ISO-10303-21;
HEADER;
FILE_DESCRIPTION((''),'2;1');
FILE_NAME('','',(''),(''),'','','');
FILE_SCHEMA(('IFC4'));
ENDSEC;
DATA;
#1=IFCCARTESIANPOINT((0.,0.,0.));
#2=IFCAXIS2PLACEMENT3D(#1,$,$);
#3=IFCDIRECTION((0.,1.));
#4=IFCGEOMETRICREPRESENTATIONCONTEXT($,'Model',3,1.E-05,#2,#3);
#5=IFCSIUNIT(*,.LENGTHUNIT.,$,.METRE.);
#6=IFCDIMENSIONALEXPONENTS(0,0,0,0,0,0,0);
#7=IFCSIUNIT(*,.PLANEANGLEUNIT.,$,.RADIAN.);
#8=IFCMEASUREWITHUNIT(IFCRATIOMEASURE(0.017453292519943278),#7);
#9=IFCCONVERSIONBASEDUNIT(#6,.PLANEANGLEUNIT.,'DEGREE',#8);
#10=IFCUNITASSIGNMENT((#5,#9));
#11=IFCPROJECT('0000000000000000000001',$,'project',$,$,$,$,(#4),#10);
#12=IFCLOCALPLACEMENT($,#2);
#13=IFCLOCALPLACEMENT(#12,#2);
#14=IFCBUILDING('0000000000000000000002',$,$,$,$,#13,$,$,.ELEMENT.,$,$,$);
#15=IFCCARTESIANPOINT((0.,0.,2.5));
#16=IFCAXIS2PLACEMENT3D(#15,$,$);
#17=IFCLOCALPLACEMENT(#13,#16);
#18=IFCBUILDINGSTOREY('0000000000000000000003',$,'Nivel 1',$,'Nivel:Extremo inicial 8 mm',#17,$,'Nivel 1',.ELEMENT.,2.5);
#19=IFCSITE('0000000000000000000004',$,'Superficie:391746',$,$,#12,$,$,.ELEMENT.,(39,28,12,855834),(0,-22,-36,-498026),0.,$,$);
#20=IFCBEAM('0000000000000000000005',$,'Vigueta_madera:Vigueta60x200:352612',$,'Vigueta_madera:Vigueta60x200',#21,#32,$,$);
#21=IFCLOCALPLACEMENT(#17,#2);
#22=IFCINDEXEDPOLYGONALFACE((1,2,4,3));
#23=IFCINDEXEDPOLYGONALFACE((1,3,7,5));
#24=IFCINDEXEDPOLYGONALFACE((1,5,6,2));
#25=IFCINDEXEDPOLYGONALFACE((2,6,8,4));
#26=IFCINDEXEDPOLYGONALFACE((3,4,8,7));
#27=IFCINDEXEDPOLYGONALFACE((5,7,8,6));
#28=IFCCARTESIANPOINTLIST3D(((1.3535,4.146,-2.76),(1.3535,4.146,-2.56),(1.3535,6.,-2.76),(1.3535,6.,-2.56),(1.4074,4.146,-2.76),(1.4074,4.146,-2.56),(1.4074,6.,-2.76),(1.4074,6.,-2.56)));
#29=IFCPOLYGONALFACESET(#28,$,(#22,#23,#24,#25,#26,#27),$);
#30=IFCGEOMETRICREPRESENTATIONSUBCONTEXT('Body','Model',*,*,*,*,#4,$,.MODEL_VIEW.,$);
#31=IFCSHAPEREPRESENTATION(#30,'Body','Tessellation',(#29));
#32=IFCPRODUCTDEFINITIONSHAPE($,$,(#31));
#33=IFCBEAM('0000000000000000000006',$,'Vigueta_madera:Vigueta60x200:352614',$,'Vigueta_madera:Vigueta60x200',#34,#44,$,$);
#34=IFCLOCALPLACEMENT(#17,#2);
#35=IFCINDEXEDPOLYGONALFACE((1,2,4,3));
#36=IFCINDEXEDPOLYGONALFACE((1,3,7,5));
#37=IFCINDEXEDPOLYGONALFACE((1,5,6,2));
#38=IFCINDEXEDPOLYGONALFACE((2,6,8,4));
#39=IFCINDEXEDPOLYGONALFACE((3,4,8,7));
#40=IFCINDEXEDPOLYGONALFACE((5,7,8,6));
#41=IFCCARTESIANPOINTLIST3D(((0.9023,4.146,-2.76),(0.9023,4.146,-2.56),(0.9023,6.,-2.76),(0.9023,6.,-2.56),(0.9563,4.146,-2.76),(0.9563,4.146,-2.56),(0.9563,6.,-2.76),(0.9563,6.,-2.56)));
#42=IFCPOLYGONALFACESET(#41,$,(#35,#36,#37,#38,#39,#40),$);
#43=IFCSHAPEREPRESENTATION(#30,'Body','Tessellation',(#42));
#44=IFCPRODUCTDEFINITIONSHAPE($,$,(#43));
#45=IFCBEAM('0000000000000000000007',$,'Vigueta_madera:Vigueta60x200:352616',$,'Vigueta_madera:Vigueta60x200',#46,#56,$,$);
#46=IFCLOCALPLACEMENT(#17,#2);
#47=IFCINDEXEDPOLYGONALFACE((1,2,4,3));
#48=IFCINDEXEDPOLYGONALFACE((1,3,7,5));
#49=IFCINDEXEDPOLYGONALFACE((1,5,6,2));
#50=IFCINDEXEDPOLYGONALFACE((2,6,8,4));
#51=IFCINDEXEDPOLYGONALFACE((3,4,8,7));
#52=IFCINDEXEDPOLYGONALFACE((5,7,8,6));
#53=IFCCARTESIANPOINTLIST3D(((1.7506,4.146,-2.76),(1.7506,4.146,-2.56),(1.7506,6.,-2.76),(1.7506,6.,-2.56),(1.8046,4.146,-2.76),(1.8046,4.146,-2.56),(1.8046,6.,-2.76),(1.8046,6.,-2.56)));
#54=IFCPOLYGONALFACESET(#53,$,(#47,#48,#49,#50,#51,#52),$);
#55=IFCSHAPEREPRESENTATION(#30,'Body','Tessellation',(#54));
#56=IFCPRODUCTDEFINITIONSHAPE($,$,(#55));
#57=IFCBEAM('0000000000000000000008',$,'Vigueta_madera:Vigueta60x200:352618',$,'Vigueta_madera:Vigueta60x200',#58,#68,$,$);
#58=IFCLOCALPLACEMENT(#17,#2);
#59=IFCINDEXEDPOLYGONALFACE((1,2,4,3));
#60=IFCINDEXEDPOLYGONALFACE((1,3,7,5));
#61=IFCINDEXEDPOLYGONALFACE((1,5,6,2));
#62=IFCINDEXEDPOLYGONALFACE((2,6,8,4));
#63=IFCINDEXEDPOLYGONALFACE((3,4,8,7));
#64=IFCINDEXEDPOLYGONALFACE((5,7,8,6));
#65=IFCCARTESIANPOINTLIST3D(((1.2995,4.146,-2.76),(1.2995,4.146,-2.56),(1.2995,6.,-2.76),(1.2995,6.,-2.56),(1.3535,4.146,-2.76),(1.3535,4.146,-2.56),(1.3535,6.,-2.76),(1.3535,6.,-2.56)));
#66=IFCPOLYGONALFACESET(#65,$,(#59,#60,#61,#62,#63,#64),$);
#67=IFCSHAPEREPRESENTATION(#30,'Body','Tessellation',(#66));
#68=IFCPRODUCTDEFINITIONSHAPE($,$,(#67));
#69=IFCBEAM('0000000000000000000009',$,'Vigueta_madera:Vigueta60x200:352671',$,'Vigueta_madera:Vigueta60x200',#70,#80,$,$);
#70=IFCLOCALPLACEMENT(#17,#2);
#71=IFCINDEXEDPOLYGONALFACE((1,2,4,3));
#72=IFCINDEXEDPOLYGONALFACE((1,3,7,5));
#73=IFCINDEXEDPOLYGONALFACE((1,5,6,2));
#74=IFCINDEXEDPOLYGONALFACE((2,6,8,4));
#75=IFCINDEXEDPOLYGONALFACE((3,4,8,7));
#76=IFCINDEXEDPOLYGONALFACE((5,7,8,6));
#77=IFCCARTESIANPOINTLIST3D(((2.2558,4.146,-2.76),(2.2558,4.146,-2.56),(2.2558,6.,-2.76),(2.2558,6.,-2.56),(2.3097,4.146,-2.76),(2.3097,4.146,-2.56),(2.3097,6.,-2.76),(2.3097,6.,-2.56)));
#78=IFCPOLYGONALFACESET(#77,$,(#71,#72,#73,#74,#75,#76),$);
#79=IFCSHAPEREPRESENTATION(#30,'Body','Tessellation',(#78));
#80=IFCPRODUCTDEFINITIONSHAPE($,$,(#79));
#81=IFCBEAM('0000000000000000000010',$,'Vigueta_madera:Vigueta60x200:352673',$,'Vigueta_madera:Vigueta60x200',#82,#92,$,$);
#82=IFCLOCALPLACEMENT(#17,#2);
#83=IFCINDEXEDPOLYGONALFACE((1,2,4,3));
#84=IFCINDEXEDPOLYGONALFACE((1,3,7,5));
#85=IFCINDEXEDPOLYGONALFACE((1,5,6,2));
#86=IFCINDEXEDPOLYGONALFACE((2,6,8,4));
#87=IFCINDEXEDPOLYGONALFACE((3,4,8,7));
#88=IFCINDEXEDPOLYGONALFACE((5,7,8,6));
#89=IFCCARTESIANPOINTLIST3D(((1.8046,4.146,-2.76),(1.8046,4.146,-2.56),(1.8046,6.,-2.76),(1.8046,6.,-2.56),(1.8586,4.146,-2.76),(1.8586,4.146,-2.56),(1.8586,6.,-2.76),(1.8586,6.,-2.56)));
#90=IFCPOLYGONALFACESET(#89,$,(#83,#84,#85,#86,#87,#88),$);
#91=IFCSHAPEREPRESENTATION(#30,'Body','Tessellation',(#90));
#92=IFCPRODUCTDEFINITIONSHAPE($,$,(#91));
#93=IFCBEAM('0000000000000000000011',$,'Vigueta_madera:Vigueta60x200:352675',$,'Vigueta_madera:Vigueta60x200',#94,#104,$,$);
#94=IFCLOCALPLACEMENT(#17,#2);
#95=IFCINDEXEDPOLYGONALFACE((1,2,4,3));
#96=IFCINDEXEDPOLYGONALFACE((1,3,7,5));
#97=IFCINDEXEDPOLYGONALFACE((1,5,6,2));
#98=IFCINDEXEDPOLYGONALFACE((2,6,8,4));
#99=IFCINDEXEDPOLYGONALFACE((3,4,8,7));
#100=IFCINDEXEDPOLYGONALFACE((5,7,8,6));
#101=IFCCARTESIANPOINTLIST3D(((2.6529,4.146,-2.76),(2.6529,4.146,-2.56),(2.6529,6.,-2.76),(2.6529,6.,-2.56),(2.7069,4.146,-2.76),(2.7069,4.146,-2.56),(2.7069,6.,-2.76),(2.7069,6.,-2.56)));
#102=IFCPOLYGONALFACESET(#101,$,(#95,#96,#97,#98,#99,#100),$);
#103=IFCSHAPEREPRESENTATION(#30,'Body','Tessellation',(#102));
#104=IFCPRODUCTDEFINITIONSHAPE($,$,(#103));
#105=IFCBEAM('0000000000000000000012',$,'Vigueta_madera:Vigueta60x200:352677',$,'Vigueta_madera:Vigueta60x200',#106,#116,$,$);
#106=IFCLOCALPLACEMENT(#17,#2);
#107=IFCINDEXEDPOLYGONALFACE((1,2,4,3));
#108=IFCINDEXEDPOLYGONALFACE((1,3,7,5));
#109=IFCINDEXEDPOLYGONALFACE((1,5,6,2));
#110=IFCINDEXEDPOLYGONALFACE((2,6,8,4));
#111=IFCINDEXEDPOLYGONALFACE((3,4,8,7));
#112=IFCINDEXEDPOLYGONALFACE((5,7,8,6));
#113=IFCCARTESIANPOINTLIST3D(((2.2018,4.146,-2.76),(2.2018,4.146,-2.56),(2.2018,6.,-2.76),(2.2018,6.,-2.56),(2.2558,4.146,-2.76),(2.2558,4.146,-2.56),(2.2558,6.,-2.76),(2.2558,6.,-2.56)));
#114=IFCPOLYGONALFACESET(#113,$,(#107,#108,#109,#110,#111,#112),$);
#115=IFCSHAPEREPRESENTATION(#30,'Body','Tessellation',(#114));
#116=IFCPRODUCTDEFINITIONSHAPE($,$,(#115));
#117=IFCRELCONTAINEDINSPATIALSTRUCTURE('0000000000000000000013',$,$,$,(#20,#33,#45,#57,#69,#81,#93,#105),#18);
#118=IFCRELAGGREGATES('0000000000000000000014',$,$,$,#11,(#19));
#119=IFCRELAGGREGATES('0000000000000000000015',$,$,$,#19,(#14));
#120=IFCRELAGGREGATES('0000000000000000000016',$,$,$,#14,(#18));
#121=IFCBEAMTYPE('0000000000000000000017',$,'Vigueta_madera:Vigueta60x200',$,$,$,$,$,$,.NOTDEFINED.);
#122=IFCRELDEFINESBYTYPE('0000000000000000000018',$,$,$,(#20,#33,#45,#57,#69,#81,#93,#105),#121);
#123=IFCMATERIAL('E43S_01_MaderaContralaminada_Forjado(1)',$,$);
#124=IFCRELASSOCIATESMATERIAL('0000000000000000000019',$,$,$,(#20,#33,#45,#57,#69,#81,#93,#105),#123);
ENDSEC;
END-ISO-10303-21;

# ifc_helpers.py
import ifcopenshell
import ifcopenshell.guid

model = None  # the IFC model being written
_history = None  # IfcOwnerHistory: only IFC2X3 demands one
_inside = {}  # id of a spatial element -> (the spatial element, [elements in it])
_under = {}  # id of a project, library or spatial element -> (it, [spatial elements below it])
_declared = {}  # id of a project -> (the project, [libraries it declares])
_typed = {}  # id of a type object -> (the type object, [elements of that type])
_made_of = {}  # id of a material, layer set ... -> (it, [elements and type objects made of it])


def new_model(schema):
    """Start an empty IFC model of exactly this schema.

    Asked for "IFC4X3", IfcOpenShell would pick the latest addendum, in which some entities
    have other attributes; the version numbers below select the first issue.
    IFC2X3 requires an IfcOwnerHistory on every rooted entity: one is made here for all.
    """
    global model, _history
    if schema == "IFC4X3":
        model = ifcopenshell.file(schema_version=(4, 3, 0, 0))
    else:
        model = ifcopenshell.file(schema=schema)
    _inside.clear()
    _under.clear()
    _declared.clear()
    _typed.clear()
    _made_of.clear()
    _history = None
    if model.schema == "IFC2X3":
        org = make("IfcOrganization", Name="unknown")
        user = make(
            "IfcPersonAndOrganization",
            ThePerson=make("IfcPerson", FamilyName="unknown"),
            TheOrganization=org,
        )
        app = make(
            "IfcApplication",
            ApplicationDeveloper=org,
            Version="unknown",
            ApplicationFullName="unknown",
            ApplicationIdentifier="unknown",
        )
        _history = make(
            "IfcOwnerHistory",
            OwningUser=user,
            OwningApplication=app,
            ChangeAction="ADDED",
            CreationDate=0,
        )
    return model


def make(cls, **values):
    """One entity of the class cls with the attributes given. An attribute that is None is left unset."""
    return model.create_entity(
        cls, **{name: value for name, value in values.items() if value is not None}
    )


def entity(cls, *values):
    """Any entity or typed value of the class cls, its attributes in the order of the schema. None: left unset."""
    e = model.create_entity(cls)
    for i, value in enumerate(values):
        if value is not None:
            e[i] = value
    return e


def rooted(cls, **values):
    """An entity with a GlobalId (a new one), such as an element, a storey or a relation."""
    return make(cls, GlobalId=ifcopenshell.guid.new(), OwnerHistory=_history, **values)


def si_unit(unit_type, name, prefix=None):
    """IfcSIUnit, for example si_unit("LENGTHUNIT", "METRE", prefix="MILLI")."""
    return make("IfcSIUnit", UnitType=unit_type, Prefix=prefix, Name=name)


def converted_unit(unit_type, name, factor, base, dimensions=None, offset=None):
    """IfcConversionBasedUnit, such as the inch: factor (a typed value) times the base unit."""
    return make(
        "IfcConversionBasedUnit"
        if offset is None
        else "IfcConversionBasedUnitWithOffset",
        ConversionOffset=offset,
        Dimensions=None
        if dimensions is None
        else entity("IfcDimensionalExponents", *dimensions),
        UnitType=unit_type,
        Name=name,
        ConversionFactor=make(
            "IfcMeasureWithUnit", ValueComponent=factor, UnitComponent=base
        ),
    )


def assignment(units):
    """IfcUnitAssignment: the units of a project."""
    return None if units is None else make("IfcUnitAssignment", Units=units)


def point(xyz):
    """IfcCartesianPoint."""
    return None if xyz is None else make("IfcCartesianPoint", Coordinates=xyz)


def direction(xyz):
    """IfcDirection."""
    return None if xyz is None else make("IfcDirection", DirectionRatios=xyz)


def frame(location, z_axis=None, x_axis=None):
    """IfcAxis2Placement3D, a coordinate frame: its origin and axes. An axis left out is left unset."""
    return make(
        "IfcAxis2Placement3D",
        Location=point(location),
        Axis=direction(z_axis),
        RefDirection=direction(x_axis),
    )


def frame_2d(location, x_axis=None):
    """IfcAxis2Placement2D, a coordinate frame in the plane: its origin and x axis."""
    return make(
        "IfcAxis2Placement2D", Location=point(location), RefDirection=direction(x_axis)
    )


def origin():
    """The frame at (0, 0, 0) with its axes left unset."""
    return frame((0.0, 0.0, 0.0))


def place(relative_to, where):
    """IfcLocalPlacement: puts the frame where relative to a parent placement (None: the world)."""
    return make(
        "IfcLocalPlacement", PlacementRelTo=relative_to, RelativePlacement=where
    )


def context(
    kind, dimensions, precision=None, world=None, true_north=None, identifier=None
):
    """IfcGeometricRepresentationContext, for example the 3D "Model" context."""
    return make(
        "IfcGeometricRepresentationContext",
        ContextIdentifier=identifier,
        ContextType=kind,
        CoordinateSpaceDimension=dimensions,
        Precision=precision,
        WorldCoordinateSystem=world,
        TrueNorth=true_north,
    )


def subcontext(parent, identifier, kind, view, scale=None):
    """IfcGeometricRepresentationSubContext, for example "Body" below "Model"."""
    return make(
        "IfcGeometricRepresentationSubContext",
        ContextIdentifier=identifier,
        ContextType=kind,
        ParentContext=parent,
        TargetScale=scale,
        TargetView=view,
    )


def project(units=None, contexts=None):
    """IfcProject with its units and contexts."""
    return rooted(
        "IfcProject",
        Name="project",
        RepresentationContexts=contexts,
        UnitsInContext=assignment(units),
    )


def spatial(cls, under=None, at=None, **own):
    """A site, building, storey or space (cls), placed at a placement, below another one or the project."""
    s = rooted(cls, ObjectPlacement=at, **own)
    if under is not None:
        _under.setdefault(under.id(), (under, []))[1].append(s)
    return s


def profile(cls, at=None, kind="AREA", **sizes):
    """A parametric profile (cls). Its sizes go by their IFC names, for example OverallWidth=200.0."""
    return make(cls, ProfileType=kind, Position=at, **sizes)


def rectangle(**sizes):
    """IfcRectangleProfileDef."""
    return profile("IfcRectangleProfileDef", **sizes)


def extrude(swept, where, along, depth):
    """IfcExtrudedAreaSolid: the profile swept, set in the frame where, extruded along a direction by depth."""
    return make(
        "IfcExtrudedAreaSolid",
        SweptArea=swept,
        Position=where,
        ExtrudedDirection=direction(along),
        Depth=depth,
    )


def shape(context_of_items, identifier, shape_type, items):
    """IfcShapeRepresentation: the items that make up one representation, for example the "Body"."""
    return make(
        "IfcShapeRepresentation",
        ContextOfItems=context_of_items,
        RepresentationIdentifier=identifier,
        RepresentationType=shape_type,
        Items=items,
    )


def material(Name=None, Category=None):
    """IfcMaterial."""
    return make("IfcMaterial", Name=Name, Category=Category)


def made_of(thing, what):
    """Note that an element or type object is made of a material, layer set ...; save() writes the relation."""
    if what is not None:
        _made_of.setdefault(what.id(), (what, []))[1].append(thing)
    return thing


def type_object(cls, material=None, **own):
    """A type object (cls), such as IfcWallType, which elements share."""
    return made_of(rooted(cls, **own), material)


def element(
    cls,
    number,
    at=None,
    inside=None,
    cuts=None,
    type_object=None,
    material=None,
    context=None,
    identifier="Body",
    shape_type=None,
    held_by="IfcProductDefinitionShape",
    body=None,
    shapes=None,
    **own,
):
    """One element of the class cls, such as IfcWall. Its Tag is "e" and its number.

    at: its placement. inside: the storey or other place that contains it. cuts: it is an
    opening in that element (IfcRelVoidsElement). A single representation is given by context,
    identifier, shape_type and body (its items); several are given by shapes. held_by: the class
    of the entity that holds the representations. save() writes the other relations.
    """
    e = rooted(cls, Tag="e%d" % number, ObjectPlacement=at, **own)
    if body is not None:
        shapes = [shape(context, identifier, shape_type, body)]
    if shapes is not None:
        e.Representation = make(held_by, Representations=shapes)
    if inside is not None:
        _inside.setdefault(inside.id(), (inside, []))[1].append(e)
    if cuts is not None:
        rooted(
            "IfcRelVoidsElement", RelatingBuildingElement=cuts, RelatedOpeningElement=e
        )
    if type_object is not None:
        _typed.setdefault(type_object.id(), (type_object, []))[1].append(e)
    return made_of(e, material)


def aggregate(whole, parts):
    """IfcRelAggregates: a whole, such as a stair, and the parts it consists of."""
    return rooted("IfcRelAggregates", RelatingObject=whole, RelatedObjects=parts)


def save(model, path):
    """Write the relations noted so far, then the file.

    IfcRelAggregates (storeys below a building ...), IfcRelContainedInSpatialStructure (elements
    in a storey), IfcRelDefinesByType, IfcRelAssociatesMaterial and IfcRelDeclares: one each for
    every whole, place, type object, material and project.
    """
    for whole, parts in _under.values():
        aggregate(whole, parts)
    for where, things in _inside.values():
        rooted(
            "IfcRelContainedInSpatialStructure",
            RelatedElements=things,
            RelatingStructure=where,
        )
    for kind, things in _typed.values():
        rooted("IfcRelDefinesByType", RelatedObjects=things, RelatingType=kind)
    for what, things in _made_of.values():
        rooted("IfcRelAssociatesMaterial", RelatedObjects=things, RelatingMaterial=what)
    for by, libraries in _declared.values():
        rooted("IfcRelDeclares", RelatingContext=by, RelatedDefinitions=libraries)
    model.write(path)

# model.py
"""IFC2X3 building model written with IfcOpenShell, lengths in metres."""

from ifc_helpers import new_model, entity, si_unit, converted_unit, direction, frame, frame_2d, origin, place, context, subcontext, project, spatial, rectangle, extrude, material, type_object, element, save


model = new_model("IFC2X3")

# Units and contexts
model_context = context("Model", 3, precision=1e-05, world=origin(), true_north=direction((0.0, 1.0)))
body_context = subcontext(model_context, "Body", "Model", "MODEL_VIEW")
ifc_project = project(units=[si_unit("LENGTHUNIT", "METRE"), converted_unit("PLANEANGLEUNIT", "DEGREE", entity("IfcRatioMeasure", 0.017453292519943278), si_unit("PLANEANGLEUNIT", "RADIAN"), dimensions=[0, 0, 0, 0, 0, 0, 0])], contexts=[model_context])

# Site, building, storey
site_placement = place(None, origin())
site = spatial("IfcSite", under=ifc_project, at=site_placement, Name="Superficie:391746", CompositionType="ELEMENT", RefLatitude=(39, 28, 12, 855834), RefLongitude=(0, -22, -36, -498026), RefElevation=0.0)
building_placement = place(site_placement, origin())
building = spatial("IfcBuilding", under=site, at=building_placement, CompositionType="ELEMENT")
storey_placement = place(building_placement, frame((0.0, 0.0, 2.5)))
storey = spatial("IfcBuildingStorey", under=building, at=storey_placement, Name="Nivel 1", ObjectType="Nivel:Extremo inicial 8 mm", LongName="Nivel 1", CompositionType="ELEMENT", Elevation=2.5)

# Beams
ifc_material = material(Name="E43S_01_MaderaContralaminada_Forjado(1)")
beam_type = type_object("IfcBeamType", Name="Vigueta_madera:Vigueta60x200", PredefinedType="NOTDEFINED")
beam_1_placement = place(storey_placement, frame((1.3804, 4.146, -2.56), z_axis=(0.0, 0.0, 1.0), x_axis=(0.0, 1.0, 0.0)))
element("IfcBeam", 1, at=beam_1_placement, inside=storey, type_object=beam_type, material=ifc_material, Name="Vigueta_madera:Vigueta60x200:352612", ObjectType="Vigueta_madera:Vigueta60x200", context=body_context, shape_type="SweptSolid", body=[
    extrude(rectangle(XDim=0.2, YDim=0.054, at=frame_2d((0.0, 0.0), x_axis=(1.0, 0.0))), frame((0.0, 0.0, -0.1), z_axis=(1.0, 0.0, 0.0), x_axis=(0.0, 0.0, -1.0)), (0.0, 0.0, 1.0), 1.854),
])
beam_2_placement = place(storey_placement, frame((0.9293, 4.146, -2.56), z_axis=(0.0, 0.0, 1.0), x_axis=(0.0, 1.0, 0.0)))
element("IfcBeam", 2, at=beam_2_placement, inside=storey, type_object=beam_type, material=ifc_material, Name="Vigueta_madera:Vigueta60x200:352614", ObjectType="Vigueta_madera:Vigueta60x200", context=body_context, shape_type="SweptSolid", body=[
    extrude(rectangle(XDim=0.2, YDim=0.054, at=frame_2d((0.0, 0.0), x_axis=(1.0, 0.0))), frame((0.0, 0.0, -0.1), z_axis=(1.0, 0.0, 0.0), x_axis=(0.0, 0.0, -1.0)), (0.0, 0.0, 1.0), 1.854),
])
beam_3_placement = place(storey_placement, frame((1.7776, 4.146, -2.56), z_axis=(0.0, 0.0, 1.0), x_axis=(0.0, 1.0, 0.0)))
element("IfcBeam", 3, at=beam_3_placement, inside=storey, type_object=beam_type, material=ifc_material, Name="Vigueta_madera:Vigueta60x200:352616", ObjectType="Vigueta_madera:Vigueta60x200", context=body_context, shape_type="SweptSolid", body=[
    extrude(rectangle(XDim=0.2, YDim=0.054, at=frame_2d((0.0, 0.0), x_axis=(1.0, 0.0))), frame((0.0, 0.0, -0.1), z_axis=(1.0, 0.0, 0.0), x_axis=(0.0, 0.0, -1.0)), (0.0, 0.0, 1.0), 1.854),
])
beam_4_placement = place(storey_placement, frame((1.3265, 4.146, -2.56), z_axis=(0.0, 0.0, 1.0), x_axis=(0.0, 1.0, 0.0)))
element("IfcBeam", 4, at=beam_4_placement, inside=storey, type_object=beam_type, material=ifc_material, Name="Vigueta_madera:Vigueta60x200:352618", ObjectType="Vigueta_madera:Vigueta60x200", context=body_context, shape_type="SweptSolid", body=[
    extrude(rectangle(XDim=0.2, YDim=0.054, at=frame_2d((0.0, 0.0), x_axis=(1.0, 0.0))), frame((0.0, 0.0, -0.1), z_axis=(1.0, 0.0, 0.0), x_axis=(0.0, 0.0, -1.0)), (0.0, 0.0, 1.0), 1.854),
])
beam_5_placement = place(storey_placement, frame((2.2827, 4.146, -2.56), z_axis=(0.0, 0.0, 1.0), x_axis=(0.0, 1.0, 0.0)))
element("IfcBeam", 5, at=beam_5_placement, inside=storey, type_object=beam_type, material=ifc_material, Name="Vigueta_madera:Vigueta60x200:352671", ObjectType="Vigueta_madera:Vigueta60x200", context=body_context, shape_type="SweptSolid", body=[
    extrude(rectangle(XDim=0.2, YDim=0.054, at=frame_2d((0.0, 0.0), x_axis=(1.0, 0.0))), frame((0.0, 0.0, -0.1), z_axis=(1.0, 0.0, 0.0), x_axis=(0.0, 0.0, -1.0)), (0.0, 0.0, 1.0), 1.854),
])
beam_6_placement = place(storey_placement, frame((1.8316, 4.146, -2.56), z_axis=(0.0, 0.0, 1.0), x_axis=(0.0, 1.0, 0.0)))
element("IfcBeam", 6, at=beam_6_placement, inside=storey, type_object=beam_type, material=ifc_material, Name="Vigueta_madera:Vigueta60x200:352673", ObjectType="Vigueta_madera:Vigueta60x200", context=body_context, shape_type="SweptSolid", body=[
    extrude(rectangle(XDim=0.2, YDim=0.054, at=frame_2d((0.0, 0.0), x_axis=(1.0, 0.0))), frame((0.0, 0.0, -0.1), z_axis=(1.0, 0.0, 0.0), x_axis=(0.0, 0.0, -1.0)), (0.0, 0.0, 1.0), 1.854),
])
beam_7_placement = place(storey_placement, frame((2.6799, 4.146, -2.56), z_axis=(0.0, 0.0, 1.0), x_axis=(0.0, 1.0, 0.0)))
element("IfcBeam", 7, at=beam_7_placement, inside=storey, type_object=beam_type, material=ifc_material, Name="Vigueta_madera:Vigueta60x200:352675", ObjectType="Vigueta_madera:Vigueta60x200", context=body_context, shape_type="SweptSolid", body=[
    extrude(rectangle(XDim=0.2, YDim=0.054, at=frame_2d((0.0, 0.0), x_axis=(1.0, 0.0))), frame((0.0, 0.0, -0.1), z_axis=(1.0, 0.0, 0.0), x_axis=(0.0, 0.0, -1.0)), (0.0, 0.0, 1.0), 1.854),
])
beam_8_placement = place(storey_placement, frame((2.2288, 4.146, -2.56), z_axis=(0.0, 0.0, 1.0), x_axis=(0.0, 1.0, 0.0)))
element("IfcBeam", 8, at=beam_8_placement, inside=storey, type_object=beam_type, material=ifc_material, Name="Vigueta_madera:Vigueta60x200:352677", ObjectType="Vigueta_madera:Vigueta60x200", context=body_context, shape_type="SweptSolid", body=[
    extrude(rectangle(XDim=0.2, YDim=0.054, at=frame_2d((0.0, 0.0), x_axis=(1.0, 0.0))), frame((0.0, 0.0, -0.1), z_axis=(1.0, 0.0, 0.0), x_axis=(0.0, 0.0, -1.0)), (0.0, 0.0, 1.0), 1.854),
])

save(model, "model.ifc")
